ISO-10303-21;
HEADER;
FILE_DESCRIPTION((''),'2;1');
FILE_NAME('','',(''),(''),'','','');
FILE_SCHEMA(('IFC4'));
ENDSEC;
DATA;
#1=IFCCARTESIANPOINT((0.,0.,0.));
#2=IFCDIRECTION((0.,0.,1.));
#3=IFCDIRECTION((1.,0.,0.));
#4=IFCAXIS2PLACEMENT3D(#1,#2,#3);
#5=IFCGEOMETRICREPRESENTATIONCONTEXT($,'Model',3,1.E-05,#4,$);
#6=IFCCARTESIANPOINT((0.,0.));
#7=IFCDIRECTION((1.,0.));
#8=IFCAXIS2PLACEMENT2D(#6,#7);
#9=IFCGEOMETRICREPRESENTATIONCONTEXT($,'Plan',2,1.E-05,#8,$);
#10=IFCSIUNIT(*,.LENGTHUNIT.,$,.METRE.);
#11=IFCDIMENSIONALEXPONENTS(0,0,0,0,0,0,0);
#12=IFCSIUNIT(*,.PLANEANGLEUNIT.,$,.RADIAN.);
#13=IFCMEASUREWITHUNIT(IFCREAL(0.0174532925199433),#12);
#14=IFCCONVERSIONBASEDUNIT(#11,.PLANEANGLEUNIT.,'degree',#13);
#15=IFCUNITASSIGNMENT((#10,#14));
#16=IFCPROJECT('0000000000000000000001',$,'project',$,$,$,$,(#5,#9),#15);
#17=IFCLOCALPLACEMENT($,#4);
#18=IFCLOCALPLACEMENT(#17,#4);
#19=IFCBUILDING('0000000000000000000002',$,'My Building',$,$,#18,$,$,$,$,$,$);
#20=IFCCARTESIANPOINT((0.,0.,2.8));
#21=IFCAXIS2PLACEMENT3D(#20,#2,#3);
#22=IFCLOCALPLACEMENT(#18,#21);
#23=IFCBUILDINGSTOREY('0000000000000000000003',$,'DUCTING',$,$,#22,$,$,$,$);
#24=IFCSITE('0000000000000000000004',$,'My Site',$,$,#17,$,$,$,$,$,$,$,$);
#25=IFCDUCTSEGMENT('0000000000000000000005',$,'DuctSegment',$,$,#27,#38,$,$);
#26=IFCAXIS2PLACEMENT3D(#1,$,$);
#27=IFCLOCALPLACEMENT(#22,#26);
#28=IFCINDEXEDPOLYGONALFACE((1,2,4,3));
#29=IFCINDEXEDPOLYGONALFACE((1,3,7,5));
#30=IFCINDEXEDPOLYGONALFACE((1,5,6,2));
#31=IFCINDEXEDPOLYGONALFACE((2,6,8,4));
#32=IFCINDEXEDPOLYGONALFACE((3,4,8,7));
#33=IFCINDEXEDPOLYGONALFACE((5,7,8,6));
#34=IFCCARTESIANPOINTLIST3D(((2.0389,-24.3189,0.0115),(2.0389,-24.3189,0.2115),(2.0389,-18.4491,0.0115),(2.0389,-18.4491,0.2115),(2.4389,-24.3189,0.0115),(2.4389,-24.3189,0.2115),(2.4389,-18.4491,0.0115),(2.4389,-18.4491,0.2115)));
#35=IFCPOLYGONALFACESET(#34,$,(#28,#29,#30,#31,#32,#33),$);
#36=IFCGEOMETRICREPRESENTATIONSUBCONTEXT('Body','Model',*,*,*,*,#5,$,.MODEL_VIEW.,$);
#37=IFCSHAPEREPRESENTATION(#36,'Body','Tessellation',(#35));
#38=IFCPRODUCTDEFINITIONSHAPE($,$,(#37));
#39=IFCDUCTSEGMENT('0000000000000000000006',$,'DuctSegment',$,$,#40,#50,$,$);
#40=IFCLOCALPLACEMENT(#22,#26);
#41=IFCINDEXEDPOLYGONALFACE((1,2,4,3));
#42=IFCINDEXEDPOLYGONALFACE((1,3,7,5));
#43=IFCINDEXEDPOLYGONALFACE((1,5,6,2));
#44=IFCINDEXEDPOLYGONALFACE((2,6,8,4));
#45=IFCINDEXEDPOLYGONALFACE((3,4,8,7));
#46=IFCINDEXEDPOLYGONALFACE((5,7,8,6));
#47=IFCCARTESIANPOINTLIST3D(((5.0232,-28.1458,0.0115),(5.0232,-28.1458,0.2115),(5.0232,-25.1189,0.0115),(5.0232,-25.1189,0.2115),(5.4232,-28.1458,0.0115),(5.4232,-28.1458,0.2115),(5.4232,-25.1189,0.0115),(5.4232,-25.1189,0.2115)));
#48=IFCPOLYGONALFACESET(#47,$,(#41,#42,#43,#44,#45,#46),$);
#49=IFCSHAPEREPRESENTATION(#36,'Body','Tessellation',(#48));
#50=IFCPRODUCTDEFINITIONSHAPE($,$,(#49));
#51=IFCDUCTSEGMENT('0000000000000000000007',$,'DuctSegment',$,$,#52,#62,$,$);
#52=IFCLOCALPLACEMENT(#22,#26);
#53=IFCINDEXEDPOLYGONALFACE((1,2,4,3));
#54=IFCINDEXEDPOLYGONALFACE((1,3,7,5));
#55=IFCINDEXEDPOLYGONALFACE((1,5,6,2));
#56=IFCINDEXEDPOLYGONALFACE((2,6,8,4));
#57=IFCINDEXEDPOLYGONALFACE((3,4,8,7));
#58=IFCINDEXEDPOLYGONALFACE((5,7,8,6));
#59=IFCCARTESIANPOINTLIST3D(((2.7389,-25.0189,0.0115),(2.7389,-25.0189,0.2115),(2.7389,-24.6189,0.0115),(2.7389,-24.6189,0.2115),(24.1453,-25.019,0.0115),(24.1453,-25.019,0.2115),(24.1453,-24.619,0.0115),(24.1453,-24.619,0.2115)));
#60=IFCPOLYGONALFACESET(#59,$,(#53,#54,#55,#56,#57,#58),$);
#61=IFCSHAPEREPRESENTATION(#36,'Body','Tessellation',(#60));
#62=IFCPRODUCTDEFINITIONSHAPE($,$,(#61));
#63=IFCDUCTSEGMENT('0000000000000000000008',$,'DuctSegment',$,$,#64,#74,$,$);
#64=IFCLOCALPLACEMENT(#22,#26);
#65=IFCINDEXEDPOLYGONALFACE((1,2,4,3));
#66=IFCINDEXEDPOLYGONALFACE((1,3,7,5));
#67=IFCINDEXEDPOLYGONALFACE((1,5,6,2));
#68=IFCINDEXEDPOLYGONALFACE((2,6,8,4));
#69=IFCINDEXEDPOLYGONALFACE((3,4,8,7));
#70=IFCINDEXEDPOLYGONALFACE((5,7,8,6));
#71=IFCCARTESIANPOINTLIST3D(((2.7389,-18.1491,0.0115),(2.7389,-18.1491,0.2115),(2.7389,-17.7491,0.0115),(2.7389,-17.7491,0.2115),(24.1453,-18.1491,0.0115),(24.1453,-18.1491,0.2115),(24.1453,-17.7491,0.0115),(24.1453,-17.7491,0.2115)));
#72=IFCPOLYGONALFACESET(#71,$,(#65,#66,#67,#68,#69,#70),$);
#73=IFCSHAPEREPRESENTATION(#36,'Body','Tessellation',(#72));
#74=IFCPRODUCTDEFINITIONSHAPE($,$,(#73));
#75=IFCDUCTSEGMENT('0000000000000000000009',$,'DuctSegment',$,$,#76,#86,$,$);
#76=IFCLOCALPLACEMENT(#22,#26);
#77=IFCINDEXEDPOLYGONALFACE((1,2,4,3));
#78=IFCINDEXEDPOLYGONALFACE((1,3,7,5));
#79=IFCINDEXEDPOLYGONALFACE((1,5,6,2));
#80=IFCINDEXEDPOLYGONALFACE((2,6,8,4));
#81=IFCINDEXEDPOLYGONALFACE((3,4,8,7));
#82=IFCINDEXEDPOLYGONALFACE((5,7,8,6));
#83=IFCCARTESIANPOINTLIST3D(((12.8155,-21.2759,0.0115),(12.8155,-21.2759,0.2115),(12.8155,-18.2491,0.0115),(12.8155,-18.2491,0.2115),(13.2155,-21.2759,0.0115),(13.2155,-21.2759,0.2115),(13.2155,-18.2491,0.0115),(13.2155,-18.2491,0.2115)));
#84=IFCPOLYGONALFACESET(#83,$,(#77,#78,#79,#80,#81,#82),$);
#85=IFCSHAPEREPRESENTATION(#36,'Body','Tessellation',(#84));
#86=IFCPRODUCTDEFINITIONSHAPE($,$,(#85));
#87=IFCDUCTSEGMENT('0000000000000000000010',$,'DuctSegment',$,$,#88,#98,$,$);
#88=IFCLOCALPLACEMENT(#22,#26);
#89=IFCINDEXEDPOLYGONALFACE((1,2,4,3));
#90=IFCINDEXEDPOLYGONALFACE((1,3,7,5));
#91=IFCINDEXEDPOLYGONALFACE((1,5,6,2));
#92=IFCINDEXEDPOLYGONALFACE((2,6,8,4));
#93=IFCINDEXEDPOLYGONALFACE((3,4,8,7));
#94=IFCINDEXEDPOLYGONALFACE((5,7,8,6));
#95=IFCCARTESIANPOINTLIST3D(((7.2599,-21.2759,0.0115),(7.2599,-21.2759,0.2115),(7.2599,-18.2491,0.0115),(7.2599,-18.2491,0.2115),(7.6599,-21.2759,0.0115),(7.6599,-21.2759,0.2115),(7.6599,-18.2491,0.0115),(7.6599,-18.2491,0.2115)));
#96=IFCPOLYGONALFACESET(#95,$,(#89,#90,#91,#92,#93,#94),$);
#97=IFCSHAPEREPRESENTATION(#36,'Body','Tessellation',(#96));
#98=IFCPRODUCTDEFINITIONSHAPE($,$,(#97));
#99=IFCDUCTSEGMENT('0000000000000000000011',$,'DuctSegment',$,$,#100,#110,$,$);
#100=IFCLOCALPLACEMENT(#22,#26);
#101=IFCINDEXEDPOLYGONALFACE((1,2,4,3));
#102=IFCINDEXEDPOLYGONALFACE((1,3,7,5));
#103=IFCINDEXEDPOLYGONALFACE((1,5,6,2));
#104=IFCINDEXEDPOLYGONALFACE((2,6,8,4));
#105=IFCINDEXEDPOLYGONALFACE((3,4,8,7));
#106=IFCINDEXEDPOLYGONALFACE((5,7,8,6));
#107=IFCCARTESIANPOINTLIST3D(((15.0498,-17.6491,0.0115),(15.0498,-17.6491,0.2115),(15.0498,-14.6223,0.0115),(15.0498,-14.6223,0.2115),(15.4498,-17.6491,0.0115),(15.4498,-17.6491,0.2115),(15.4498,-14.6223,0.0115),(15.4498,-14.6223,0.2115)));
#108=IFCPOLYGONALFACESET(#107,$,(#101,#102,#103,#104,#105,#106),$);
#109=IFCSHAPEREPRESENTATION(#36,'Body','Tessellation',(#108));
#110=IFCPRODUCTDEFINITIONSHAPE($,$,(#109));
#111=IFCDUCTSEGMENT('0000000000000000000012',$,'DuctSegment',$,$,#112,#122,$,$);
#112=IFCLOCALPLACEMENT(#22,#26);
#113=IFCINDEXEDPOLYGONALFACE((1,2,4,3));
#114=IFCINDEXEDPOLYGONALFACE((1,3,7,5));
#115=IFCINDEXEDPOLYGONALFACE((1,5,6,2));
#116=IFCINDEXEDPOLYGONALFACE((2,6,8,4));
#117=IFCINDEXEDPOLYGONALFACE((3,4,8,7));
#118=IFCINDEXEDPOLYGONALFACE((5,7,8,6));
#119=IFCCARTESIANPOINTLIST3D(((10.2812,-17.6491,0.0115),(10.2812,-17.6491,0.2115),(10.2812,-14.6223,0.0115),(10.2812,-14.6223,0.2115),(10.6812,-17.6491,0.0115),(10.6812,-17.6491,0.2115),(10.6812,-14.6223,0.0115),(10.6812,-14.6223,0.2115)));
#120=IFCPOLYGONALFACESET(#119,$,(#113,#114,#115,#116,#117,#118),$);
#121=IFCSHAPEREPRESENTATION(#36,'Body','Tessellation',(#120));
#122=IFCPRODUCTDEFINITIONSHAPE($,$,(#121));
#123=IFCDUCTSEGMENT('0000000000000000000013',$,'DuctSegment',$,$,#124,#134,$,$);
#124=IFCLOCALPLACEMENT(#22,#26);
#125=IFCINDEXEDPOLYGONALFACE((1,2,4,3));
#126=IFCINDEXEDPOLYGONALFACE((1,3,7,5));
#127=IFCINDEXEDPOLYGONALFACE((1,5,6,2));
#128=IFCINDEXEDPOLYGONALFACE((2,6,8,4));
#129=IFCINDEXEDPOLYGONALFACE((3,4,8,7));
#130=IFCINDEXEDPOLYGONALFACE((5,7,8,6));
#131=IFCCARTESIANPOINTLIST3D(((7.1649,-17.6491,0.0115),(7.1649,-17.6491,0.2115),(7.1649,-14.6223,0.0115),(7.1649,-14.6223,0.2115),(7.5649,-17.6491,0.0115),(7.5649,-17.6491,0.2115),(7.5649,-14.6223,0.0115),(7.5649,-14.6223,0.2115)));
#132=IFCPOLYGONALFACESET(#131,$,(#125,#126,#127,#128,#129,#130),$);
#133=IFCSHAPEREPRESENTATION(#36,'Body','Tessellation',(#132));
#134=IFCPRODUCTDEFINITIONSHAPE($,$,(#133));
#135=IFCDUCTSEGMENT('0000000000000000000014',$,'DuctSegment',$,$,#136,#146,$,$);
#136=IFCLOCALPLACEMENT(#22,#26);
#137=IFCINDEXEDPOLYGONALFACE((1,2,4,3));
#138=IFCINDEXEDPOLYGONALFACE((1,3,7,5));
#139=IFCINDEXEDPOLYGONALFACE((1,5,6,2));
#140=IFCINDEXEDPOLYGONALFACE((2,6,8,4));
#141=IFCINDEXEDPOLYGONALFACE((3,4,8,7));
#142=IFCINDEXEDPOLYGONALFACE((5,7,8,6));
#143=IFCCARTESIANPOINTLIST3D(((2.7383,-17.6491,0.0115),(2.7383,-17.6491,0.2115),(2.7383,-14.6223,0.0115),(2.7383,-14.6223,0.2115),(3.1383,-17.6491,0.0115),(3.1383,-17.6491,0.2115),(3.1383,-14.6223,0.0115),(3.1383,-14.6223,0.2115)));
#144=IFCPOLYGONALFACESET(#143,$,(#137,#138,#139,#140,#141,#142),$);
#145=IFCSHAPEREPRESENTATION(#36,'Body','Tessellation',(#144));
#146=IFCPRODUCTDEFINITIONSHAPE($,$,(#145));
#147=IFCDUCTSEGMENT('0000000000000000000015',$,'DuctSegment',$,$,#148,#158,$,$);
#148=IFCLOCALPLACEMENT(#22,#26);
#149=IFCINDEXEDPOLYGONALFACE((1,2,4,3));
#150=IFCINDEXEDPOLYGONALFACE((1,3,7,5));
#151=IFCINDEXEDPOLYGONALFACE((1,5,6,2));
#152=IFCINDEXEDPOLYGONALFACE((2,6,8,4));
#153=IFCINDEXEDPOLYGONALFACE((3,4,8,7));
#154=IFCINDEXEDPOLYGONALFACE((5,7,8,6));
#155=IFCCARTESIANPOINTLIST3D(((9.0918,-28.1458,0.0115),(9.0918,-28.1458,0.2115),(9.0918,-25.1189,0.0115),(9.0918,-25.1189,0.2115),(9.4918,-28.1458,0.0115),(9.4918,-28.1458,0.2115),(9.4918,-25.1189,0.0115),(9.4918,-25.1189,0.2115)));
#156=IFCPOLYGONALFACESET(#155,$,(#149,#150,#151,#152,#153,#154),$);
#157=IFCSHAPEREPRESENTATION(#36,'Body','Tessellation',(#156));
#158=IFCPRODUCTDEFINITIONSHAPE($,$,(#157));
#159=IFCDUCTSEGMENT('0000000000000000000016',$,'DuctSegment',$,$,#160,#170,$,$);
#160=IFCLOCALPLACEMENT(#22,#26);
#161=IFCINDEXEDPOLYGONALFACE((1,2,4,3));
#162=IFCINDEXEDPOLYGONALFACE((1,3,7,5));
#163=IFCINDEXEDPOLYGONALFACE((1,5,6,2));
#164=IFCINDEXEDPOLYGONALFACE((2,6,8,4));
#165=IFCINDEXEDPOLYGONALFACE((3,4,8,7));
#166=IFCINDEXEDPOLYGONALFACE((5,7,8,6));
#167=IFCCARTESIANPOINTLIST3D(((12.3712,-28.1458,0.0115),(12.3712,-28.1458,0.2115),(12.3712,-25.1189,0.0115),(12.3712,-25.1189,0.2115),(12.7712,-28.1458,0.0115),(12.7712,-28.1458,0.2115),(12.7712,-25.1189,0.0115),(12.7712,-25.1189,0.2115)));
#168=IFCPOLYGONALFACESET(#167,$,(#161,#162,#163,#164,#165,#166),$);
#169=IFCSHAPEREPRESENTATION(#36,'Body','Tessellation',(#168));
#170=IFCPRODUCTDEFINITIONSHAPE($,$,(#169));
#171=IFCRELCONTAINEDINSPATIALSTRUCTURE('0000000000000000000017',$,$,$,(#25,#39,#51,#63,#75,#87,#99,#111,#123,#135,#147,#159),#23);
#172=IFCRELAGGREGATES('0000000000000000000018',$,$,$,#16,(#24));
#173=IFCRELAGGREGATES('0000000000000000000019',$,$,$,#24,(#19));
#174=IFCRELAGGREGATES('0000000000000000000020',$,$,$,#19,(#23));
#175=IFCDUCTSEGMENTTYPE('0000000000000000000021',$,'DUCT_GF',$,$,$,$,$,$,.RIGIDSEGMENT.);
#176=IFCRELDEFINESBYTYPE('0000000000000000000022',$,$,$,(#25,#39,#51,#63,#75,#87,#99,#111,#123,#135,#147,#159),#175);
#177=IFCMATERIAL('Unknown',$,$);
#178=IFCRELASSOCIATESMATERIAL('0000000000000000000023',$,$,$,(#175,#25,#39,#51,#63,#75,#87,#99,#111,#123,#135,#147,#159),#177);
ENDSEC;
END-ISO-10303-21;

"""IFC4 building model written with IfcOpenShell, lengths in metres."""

from ifc_helpers import new_model, entity, si_unit, converted_unit, frame, origin_with_axes, origin_2d_with_axis, place, context, subcontext, project, spatial, rectangle, extrude, material, material_profile, profile_set, profile_usage, type_object, element, save


model = new_model("IFC4")

# Units and contexts
model_context = context("Model", 3, precision=1e-05, world=origin_with_axes())
plan_context = context("Plan", 2, precision=1e-05, world=origin_2d_with_axis())
body_context = subcontext(model_context, "Body", "Model", "MODEL_VIEW")
ifc_project = project(units=[si_unit("LENGTHUNIT", "METRE"), converted_unit("PLANEANGLEUNIT", "degree", entity("IfcReal", 0.0174532925199433), si_unit("PLANEANGLEUNIT", "RADIAN"), dimensions=[0, 0, 0, 0, 0, 0, 0])], contexts=[model_context, plan_context])

# Site, building, storey
site_placement = place(None, origin_with_axes())
site = spatial("IfcSite", under=ifc_project, at=site_placement, Name="My Site")
building_placement = place(site_placement, origin_with_axes())
building = spatial("IfcBuilding", under=site, at=building_placement, Name="My Building")
storey_placement = place(building_placement, frame((0.0, 0.0, 2.8), z_axis=(0.0, 0.0, 1.0), x_axis=(1.0, 0.0, 0.0)))
storey = spatial("IfcBuildingStorey", under=building, at=storey_placement, Name="DUCTING")

# Duct segments
ifc_material = material(Name="Unknown")
ifc_material_profile_1 = material_profile(ifc_material, rectangle(XDim=0.4, YDim=0.2))
ifc_profile_set_1 = profile_set([ifc_material_profile_1])
ifc_profile_usage_1 = profile_usage(ifc_profile_set_1, cardinal=5)
duct_segment_type = type_object("IfcDuctSegmentType", Name="DUCT_GF", PredefinedType="RIGIDSEGMENT", material=ifc_profile_set_1)
duct_segment_1_placement = place(storey_placement, frame((2.2389, -18.4491, 0.1115), z_axis=(0.0, -1.0, 0.0), x_axis=(1.0, 0.0, 0.0)))
element("IfcDuctSegment", 1, at=duct_segment_1_placement, inside=storey, type_object=duct_segment_type, material=ifc_profile_usage_1, Name="DuctSegment", context=body_context, shape_type="SweptSolid", body=[
    extrude(rectangle(XDim=0.4, YDim=0.2), origin_with_axes(), (0.0, 0.0, 1.0), 5.8699),
])
ifc_profile_usage_2 = profile_usage(ifc_profile_set_1, cardinal=5)
duct_segment_2_placement = place(storey_placement, frame((5.2232, -25.1189, 0.1115), z_axis=(0.0, -1.0, 0.0), x_axis=(1.0, 0.0, 0.0)))
element("IfcDuctSegment", 2, at=duct_segment_2_placement, inside=storey, type_object=duct_segment_type, material=ifc_profile_usage_2, Name="DuctSegment", context=body_context, shape_type="SweptSolid", body=[
    extrude(rectangle(XDim=0.4, YDim=0.2), origin_with_axes(), (0.0, 0.0, 1.0), 3.0268),
])
ifc_profile_usage_3 = profile_usage(ifc_profile_set_1, cardinal=5)
duct_segment_3_placement = place(storey_placement, frame((2.7389, -24.8189, 0.1115), z_axis=(1.0, -0.000001, 0.000001), x_axis=(0.000001, 1.0, 0.0)))
element("IfcDuctSegment", 3, at=duct_segment_3_placement, inside=storey, type_object=duct_segment_type, material=ifc_profile_usage_3, Name="DuctSegment", context=body_context, shape_type="SweptSolid", body=[
    extrude(rectangle(XDim=0.4, YDim=0.2), origin_with_axes(), (0.0, 0.0, 1.0), 21.4064),
])
ifc_profile_usage_4 = profile_usage(ifc_profile_set_1, cardinal=5)
duct_segment_4_placement = place(storey_placement, frame((2.7389, -17.9491, 0.1115), z_axis=(1.0, -0.000001, 0.000001), x_axis=(0.000001, 1.0, 0.0)))
element("IfcDuctSegment", 4, at=duct_segment_4_placement, inside=storey, type_object=duct_segment_type, material=ifc_profile_usage_4, Name="DuctSegment", context=body_context, shape_type="SweptSolid", body=[
    extrude(rectangle(XDim=0.4, YDim=0.2), origin_with_axes(), (0.0, 0.0, 1.0), 21.4064),
])
ifc_profile_usage_5 = profile_usage(ifc_profile_set_1, cardinal=5)
duct_segment_5_placement = place(storey_placement, frame((13.0155, -18.2491, 0.1115), z_axis=(0.000001, -1.0, 0.0), x_axis=(1.0, 0.000001, 0.0)))
element("IfcDuctSegment", 5, at=duct_segment_5_placement, inside=storey, type_object=duct_segment_type, material=ifc_profile_usage_5, Name="DuctSegment", context=body_context, shape_type="SweptSolid", body=[
    extrude(rectangle(XDim=0.4, YDim=0.2), origin_with_axes(), (0.0, 0.0, 1.0), 3.0268),
])
ifc_profile_usage_6 = profile_usage(ifc_profile_set_1, cardinal=5)
duct_segment_6_placement = place(storey_placement, frame((7.4599, -18.2491, 0.1115), z_axis=(0.000001, -1.0, 0.0), x_axis=(1.0, 0.000001, 0.0)))
element("IfcDuctSegment", 6, at=duct_segment_6_placement, inside=storey, type_object=duct_segment_type, material=ifc_profile_usage_6, Name="DuctSegment", context=body_context, shape_type="SweptSolid", body=[
    extrude(rectangle(XDim=0.4, YDim=0.2), origin_with_axes(), (0.0, 0.0, 1.0), 3.0268),
])
ifc_profile_usage_7 = profile_usage(ifc_profile_set_1, cardinal=5)
duct_segment_7_placement = place(storey_placement, frame((15.2498, -14.6223, 0.1115), z_axis=(0.000001, -1.0, 0.0), x_axis=(1.0, 0.000001, 0.0)))
element("IfcDuctSegment", 7, at=duct_segment_7_placement, inside=storey, type_object=duct_segment_type, material=ifc_profile_usage_7, Name="DuctSegment", context=body_context, shape_type="SweptSolid", body=[
    extrude(rectangle(XDim=0.4, YDim=0.2), origin_with_axes(), (0.0, 0.0, 1.0), 3.0268),
])
ifc_profile_usage_8 = profile_usage(ifc_profile_set_1, cardinal=5)
duct_segment_8_placement = place(storey_placement, frame((10.4812, -14.6223, 0.1115), z_axis=(0.000001, -1.0, 0.0), x_axis=(1.0, 0.000001, 0.0)))
element("IfcDuctSegment", 8, at=duct_segment_8_placement, inside=storey, type_object=duct_segment_type, material=ifc_profile_usage_8, Name="DuctSegment", context=body_context, shape_type="SweptSolid", body=[
    extrude(rectangle(XDim=0.4, YDim=0.2), origin_with_axes(), (0.0, 0.0, 1.0), 3.0268),
])
ifc_profile_usage_9 = profile_usage(ifc_profile_set_1, cardinal=5)
duct_segment_9_placement = place(storey_placement, frame((7.3649, -14.6223, 0.1115), z_axis=(0.000001, -1.0, 0.0), x_axis=(1.0, 0.000001, 0.0)))
element("IfcDuctSegment", 9, at=duct_segment_9_placement, inside=storey, type_object=duct_segment_type, material=ifc_profile_usage_9, Name="DuctSegment", context=body_context, shape_type="SweptSolid", body=[
    extrude(rectangle(XDim=0.4, YDim=0.2), origin_with_axes(), (0.0, 0.0, 1.0), 3.0268),
])
ifc_profile_usage_10 = profile_usage(ifc_profile_set_1, cardinal=5)
duct_segment_10_placement = place(storey_placement, frame((2.9383, -14.6223, 0.1115), z_axis=(0.000001, -1.0, 0.0), x_axis=(1.0, 0.000001, 0.0)))
element("IfcDuctSegment", 10, at=duct_segment_10_placement, inside=storey, type_object=duct_segment_type, material=ifc_profile_usage_10, Name="DuctSegment", context=body_context, shape_type="SweptSolid", body=[
    extrude(rectangle(XDim=0.4, YDim=0.2), origin_with_axes(), (0.0, 0.0, 1.0), 3.0268),
])
ifc_profile_usage_11 = profile_usage(ifc_profile_set_1, cardinal=5)
duct_segment_11_placement = place(storey_placement, frame((9.2918, -25.1189, 0.1115), z_axis=(0.000001, -1.0, 0.0), x_axis=(1.0, 0.000001, 0.0)))
element("IfcDuctSegment", 11, at=duct_segment_11_placement, inside=storey, type_object=duct_segment_type, material=ifc_profile_usage_11, Name="DuctSegment", context=body_context, shape_type="SweptSolid", body=[
    extrude(rectangle(XDim=0.4, YDim=0.2), origin_with_axes(), (0.0, 0.0, 1.0), 3.0268),
])
ifc_profile_usage_12 = profile_usage(ifc_profile_set_1, cardinal=5)
duct_segment_12_placement = place(storey_placement, frame((12.5712, -25.1189, 0.1115), z_axis=(0.000001, -1.0, 0.0), x_axis=(1.0, 0.000001, 0.0)))
element("IfcDuctSegment", 12, at=duct_segment_12_placement, inside=storey, type_object=duct_segment_type, material=ifc_profile_usage_12, Name="DuctSegment", context=body_context, shape_type="SweptSolid", body=[
    extrude(rectangle(XDim=0.4, YDim=0.2), origin_with_axes(), (0.0, 0.0, 1.0), 3.0268),
])

save(model, "model.ifc")
